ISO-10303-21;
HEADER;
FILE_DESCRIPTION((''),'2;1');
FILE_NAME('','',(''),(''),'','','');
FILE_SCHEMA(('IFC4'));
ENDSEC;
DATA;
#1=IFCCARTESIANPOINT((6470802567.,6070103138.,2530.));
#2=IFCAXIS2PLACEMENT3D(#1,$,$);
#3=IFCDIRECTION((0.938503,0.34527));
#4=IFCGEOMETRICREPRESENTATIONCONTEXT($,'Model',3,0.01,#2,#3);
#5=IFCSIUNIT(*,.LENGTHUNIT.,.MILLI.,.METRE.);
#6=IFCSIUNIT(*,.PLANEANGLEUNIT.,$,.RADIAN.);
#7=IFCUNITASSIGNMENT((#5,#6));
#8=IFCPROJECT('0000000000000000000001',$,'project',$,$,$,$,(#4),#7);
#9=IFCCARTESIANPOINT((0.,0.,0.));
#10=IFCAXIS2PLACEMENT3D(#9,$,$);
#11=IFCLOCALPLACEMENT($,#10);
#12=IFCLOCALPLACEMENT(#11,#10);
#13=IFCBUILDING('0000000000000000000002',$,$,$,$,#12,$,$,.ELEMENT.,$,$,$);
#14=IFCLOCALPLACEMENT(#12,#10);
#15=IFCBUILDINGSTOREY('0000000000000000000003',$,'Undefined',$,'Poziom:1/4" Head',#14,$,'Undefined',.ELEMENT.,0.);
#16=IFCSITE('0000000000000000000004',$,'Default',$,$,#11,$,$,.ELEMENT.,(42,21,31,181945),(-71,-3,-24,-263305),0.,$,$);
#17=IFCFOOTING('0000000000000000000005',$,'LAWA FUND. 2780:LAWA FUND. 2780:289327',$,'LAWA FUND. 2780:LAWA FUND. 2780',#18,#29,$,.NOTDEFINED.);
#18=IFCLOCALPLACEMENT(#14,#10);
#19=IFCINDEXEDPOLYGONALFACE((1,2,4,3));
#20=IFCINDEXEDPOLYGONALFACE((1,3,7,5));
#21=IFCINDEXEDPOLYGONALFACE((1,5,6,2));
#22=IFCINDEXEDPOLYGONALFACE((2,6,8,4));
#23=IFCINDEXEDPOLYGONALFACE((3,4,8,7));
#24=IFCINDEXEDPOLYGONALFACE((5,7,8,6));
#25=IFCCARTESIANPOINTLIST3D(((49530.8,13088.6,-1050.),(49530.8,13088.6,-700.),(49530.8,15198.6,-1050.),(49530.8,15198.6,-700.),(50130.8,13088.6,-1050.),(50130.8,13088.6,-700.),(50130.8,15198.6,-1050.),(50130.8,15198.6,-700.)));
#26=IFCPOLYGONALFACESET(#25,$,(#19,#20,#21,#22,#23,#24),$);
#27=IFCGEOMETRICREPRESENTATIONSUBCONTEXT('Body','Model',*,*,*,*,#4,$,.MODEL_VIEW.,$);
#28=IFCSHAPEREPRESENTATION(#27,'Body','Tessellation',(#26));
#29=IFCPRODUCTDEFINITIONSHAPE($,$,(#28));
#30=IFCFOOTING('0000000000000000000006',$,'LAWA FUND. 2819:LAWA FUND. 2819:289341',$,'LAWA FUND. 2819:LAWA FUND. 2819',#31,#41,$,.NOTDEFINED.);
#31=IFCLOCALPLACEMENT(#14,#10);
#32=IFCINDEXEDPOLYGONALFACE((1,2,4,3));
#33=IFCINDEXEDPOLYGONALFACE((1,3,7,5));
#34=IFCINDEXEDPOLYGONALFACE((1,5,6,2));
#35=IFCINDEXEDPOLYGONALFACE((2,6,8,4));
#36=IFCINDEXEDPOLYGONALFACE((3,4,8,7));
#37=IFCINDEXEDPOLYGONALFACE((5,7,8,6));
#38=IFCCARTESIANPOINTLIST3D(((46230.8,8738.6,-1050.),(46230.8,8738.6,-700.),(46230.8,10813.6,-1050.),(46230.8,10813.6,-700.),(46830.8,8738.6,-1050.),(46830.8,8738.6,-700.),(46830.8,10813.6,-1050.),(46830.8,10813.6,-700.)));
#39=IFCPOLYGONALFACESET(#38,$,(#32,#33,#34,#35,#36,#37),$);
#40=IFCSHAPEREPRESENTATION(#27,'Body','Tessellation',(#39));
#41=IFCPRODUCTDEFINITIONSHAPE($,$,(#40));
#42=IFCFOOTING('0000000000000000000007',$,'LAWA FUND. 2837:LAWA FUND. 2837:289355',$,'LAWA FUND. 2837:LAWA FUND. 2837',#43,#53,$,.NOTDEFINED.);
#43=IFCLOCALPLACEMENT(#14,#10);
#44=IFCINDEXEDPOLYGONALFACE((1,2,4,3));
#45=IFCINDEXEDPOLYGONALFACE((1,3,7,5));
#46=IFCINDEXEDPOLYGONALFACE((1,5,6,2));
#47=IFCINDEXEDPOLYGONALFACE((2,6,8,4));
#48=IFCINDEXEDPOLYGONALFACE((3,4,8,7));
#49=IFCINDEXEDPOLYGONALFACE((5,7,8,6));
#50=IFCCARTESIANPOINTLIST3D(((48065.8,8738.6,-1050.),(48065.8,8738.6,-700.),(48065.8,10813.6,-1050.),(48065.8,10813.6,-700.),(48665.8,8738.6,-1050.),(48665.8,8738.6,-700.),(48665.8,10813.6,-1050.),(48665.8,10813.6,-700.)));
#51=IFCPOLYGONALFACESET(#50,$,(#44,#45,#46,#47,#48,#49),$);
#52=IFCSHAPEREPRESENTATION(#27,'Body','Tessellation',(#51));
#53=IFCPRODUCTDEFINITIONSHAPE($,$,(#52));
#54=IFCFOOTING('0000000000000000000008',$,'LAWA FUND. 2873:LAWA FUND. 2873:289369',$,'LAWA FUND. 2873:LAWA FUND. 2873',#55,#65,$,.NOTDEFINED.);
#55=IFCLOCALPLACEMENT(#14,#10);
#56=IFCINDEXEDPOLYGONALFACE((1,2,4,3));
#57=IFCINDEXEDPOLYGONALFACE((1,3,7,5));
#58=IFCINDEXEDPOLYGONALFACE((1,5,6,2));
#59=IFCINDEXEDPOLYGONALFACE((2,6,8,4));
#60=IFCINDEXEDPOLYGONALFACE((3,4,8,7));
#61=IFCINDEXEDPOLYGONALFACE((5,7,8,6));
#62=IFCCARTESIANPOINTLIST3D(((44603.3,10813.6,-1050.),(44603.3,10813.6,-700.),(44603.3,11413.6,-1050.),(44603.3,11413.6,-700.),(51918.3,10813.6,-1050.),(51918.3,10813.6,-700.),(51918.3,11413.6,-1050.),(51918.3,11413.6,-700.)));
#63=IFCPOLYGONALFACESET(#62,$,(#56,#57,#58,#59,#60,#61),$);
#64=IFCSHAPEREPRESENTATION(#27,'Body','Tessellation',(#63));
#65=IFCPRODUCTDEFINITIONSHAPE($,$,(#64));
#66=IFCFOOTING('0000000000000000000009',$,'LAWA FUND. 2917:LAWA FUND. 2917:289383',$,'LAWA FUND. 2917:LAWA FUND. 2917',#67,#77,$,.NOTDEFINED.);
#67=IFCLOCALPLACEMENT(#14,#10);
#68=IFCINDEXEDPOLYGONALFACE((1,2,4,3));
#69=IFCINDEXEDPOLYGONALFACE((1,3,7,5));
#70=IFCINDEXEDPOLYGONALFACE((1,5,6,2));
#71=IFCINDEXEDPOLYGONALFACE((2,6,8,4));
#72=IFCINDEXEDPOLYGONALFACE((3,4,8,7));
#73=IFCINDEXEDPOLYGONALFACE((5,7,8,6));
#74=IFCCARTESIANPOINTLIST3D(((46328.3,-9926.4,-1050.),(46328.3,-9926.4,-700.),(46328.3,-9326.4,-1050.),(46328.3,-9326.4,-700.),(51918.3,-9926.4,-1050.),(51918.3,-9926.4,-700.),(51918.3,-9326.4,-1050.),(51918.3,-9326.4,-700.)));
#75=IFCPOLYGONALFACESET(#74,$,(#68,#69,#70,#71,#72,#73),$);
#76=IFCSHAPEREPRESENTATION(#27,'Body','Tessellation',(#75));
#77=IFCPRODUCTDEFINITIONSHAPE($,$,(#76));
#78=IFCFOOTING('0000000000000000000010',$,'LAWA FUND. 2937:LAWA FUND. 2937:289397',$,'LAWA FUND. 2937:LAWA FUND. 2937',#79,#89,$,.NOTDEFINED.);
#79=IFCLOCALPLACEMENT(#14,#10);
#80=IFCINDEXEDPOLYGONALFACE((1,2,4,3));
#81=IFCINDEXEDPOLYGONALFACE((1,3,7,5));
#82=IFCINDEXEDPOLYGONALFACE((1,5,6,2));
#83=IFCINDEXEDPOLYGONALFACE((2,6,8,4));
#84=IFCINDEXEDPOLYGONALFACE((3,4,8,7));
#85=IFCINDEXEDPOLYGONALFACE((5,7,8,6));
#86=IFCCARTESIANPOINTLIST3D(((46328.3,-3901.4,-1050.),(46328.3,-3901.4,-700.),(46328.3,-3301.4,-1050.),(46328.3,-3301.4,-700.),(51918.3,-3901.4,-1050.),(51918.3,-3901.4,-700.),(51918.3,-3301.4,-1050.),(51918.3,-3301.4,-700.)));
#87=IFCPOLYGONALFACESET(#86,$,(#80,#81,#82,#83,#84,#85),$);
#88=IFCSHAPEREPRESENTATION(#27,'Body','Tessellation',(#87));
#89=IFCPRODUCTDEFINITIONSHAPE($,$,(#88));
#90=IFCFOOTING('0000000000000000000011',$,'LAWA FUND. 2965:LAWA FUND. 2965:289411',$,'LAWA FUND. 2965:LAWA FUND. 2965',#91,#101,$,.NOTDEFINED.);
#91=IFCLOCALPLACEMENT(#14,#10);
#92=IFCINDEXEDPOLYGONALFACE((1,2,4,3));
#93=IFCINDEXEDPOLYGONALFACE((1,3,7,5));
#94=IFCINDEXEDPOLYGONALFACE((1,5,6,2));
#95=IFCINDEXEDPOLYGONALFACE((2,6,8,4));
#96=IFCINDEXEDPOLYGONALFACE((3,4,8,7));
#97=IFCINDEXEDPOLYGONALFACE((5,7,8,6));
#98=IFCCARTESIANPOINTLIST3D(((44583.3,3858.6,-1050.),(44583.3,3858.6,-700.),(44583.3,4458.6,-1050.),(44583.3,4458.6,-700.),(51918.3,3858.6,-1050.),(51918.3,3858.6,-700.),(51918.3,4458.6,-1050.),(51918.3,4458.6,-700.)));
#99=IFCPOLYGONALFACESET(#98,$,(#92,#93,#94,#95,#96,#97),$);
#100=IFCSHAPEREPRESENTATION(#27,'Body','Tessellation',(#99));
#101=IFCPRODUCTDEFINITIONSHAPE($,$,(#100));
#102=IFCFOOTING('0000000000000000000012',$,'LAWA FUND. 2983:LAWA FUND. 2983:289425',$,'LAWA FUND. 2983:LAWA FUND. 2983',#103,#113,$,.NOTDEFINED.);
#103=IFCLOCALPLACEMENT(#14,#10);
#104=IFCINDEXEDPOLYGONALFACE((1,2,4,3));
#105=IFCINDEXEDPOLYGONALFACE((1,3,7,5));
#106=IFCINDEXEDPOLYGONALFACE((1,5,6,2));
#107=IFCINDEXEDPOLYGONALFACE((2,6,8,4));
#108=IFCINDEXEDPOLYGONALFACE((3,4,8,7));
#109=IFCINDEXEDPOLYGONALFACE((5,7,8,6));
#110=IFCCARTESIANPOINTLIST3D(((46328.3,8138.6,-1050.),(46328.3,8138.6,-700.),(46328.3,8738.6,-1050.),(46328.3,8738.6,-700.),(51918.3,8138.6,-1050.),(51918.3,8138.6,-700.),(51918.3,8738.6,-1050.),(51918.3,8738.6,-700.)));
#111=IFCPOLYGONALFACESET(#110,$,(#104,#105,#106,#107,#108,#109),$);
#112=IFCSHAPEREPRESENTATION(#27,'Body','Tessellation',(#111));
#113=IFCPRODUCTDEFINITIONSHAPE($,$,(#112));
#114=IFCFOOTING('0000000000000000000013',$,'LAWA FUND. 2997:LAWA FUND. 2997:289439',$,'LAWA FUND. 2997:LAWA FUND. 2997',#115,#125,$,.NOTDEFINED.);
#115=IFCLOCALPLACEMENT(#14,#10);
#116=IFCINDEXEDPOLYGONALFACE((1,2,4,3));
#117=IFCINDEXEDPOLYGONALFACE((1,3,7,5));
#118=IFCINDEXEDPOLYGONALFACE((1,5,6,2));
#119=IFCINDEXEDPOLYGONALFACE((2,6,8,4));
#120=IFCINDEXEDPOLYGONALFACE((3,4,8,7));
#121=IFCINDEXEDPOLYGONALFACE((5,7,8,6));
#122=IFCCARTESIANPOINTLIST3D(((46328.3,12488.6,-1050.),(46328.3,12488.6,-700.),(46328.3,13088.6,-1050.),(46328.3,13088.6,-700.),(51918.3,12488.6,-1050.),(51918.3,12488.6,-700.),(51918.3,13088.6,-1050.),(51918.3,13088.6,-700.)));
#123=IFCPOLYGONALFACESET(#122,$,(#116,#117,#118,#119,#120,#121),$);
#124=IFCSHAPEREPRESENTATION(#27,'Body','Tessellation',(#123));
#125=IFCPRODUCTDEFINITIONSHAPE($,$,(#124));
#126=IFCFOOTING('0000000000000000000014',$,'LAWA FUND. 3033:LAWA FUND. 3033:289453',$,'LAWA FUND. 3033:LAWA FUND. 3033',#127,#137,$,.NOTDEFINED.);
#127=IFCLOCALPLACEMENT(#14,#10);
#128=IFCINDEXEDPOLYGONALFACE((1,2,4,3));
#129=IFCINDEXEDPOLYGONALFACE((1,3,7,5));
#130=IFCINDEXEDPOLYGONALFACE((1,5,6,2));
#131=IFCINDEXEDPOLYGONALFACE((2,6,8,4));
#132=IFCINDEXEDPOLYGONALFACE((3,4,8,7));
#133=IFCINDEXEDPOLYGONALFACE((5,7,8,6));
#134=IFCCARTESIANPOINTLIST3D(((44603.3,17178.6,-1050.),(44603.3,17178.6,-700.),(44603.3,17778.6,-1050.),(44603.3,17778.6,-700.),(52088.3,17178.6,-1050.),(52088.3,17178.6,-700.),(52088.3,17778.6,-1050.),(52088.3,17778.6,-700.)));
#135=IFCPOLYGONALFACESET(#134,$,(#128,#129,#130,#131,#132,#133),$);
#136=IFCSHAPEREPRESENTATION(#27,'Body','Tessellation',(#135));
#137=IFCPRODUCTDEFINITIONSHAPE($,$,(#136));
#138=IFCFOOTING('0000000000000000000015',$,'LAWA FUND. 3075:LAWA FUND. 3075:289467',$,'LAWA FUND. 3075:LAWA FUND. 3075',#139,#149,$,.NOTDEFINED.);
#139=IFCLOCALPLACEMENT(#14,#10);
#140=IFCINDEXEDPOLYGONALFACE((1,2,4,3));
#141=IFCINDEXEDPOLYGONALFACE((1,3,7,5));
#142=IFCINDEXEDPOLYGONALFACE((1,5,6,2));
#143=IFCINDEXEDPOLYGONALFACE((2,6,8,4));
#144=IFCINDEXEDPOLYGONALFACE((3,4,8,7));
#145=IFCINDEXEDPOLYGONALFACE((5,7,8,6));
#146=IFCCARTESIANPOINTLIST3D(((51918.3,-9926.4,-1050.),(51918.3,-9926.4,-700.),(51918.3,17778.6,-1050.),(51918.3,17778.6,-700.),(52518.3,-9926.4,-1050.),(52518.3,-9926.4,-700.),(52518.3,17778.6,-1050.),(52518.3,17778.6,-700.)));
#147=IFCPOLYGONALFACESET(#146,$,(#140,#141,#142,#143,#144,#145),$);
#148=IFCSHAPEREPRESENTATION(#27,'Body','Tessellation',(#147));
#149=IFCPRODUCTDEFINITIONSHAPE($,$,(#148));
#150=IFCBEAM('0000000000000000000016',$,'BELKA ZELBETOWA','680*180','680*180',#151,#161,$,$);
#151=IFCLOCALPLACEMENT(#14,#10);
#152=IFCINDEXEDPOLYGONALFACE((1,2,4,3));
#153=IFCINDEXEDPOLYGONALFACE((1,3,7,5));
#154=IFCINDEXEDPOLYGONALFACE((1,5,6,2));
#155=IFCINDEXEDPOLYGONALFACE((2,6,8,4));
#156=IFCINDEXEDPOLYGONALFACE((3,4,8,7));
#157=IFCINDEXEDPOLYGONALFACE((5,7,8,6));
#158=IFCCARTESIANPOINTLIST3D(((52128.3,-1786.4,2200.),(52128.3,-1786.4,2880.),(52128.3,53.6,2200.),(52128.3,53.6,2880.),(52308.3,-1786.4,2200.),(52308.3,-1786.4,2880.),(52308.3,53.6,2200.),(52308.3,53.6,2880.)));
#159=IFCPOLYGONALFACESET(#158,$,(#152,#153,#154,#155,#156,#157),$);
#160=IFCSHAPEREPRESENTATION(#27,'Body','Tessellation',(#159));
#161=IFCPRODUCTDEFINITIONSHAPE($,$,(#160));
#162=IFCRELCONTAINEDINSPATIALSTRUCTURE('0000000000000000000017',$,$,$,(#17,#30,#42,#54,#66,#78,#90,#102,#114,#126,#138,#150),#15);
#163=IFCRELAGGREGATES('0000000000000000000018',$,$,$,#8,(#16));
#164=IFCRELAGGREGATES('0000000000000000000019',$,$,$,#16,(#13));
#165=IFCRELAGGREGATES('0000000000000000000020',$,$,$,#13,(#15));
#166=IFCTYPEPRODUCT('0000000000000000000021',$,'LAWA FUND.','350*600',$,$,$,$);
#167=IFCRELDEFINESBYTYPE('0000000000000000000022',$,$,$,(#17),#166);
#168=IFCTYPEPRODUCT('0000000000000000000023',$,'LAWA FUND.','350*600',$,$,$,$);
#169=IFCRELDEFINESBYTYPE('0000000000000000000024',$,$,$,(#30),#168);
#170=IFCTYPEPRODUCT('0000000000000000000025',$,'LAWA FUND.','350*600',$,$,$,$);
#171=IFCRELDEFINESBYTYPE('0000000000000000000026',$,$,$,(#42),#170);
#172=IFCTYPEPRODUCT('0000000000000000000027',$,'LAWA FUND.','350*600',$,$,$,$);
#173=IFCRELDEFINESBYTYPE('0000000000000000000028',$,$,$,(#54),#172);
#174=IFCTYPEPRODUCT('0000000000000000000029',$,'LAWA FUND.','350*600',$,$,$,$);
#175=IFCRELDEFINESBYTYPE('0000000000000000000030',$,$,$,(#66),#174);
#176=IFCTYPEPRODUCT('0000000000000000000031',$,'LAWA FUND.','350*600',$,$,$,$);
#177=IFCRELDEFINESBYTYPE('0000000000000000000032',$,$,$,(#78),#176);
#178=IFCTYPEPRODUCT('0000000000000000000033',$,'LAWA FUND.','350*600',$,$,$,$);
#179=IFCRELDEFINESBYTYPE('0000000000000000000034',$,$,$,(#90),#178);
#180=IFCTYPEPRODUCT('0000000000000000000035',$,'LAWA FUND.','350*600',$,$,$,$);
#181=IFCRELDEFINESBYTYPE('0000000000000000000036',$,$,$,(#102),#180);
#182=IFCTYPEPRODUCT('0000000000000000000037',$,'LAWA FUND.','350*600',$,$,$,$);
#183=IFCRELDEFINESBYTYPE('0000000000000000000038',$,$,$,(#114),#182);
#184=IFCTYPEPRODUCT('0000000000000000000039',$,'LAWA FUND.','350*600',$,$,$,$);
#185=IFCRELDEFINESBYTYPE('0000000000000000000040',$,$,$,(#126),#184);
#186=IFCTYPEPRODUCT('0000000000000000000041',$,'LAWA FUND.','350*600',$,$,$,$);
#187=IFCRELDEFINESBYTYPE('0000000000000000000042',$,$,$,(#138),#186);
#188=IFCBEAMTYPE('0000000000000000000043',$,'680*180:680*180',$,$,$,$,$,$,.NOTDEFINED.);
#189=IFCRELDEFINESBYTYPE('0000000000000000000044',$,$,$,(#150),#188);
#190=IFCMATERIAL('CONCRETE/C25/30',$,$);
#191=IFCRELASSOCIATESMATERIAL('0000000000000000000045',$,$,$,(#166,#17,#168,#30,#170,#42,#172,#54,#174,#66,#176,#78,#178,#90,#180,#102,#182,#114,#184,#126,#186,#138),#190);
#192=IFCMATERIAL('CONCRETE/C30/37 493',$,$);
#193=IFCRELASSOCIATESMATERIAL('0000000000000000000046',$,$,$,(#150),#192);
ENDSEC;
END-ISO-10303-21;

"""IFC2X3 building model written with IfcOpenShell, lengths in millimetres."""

from ifc_helpers import new_model, si_unit, direction, frame, frame_2d, origin, origin_2d_with_axis, place, context, subcontext, project, spatial, rectangle, extrude, source, transform, mapped, material, type_object, type_shapes, element, save


model = new_model("IFC2X3")

# Units and contexts
model_context = context("Model", 3, precision=0.01, world=frame((6470802567.0, 6070103138.0, 2530.0)), true_north=direction((0.938503, 0.34527)))
body_context = subcontext(model_context, "Body", "Model", "MODEL_VIEW")
ifc_project = project(units=[si_unit("LENGTHUNIT", "METRE", prefix="MILLI"), si_unit("PLANEANGLEUNIT", "RADIAN")], contexts=[model_context])

# Site, building, storey
site_placement = place(None, origin())
site = spatial("IfcSite", under=ifc_project, at=site_placement, Name="Default", CompositionType="ELEMENT", RefLatitude=(42, 21, 31, 181945), RefLongitude=(-71, -3, -24, -263305), RefElevation=0.0)
building_placement = place(site_placement, origin())
building = spatial("IfcBuilding", under=site, at=building_placement, CompositionType="ELEMENT")
storey_placement = place(building_placement, origin())
storey = spatial("IfcBuildingStorey", under=building, at=storey_placement, Name="Undefined", ObjectType="Poziom:1/4\" Head", LongName="Undefined", CompositionType="ELEMENT", Elevation=0.0)

# Footings
ifc_material_1 = material(Name="CONCRETE/C25/30")
type_product_1 = type_object("IfcTypeProduct", Name="LAWA FUND.", Description="350*600", material=ifc_material_1)
shared_shape_1 = source(origin(), body_context, "Body", "SweptSolid", [
    extrude(rectangle(XDim=600.0, YDim=2110.0, at=origin_2d_with_axis()), frame((49830.8, 14143.6, -1050.0)), (0.0, 0.0, 1.0), 350.0),
])
type_shapes(type_product_1, [shared_shape_1])
footing_1_placement = place(storey_placement, origin())
element("IfcFooting", 1, at=footing_1_placement, inside=storey, type_object=type_product_1, material=ifc_material_1, Name="LAWA FUND. 2780:LAWA FUND. 2780:289327", ObjectType="LAWA FUND. 2780:LAWA FUND. 2780", PredefinedType="NOTDEFINED", context=body_context, shape_type="MappedRepresentation", body=[
    mapped(shared_shape_1, transform((0.0, 0.0, 0.0), scale=1.0)),
])
type_product_2 = type_object("IfcTypeProduct", Name="LAWA FUND.", Description="350*600", material=ifc_material_1)
shared_shape_2 = source(origin(), body_context, "Body", "SweptSolid", [
    extrude(rectangle(XDim=600.0, YDim=2075.0, at=origin_2d_with_axis()), frame((46530.8, 9776.1, -1050.0)), (0.0, 0.0, 1.0), 350.0),
])
type_shapes(type_product_2, [shared_shape_2])
footing_2_placement = place(storey_placement, origin())
element("IfcFooting", 2, at=footing_2_placement, inside=storey, type_object=type_product_2, material=ifc_material_1, Name="LAWA FUND. 2819:LAWA FUND. 2819:289341", ObjectType="LAWA FUND. 2819:LAWA FUND. 2819", PredefinedType="NOTDEFINED", context=body_context, shape_type="MappedRepresentation", body=[
    mapped(shared_shape_2, transform((0.0, 0.0, 0.0), scale=1.0)),
])
type_product_3 = type_object("IfcTypeProduct", Name="LAWA FUND.", Description="350*600", material=ifc_material_1)
shared_shape_3 = source(origin(), body_context, "Body", "SweptSolid", [
    extrude(rectangle(XDim=600.0, YDim=2075.0, at=origin_2d_with_axis()), frame((48365.8, 9776.1, -1050.0)), (0.0, 0.0, 1.0), 350.0),
])
type_shapes(type_product_3, [shared_shape_3])
footing_3_placement = place(storey_placement, origin())
element("IfcFooting", 3, at=footing_3_placement, inside=storey, type_object=type_product_3, material=ifc_material_1, Name="LAWA FUND. 2837:LAWA FUND. 2837:289355", ObjectType="LAWA FUND. 2837:LAWA FUND. 2837", PredefinedType="NOTDEFINED", context=body_context, shape_type="MappedRepresentation", body=[
    mapped(shared_shape_3, transform((0.0, 0.0, 0.0), scale=1.0)),
])
type_product_4 = type_object("IfcTypeProduct", Name="LAWA FUND.", Description="350*600", material=ifc_material_1)
shared_shape_4 = source(origin(), body_context, "Body", "SweptSolid", [
    extrude(rectangle(XDim=600.0, YDim=7315.0, at=origin_2d_with_axis()), frame((48260.8, 11113.6, -1050.0), z_axis=(0.0, 0.0, 1.0), x_axis=(0.0, 1.0, 0.0)), (0.0, 0.0, 1.0), 350.0),
])
type_shapes(type_product_4, [shared_shape_4])
footing_4_placement = place(storey_placement, origin())
element("IfcFooting", 4, at=footing_4_placement, inside=storey, type_object=type_product_4, material=ifc_material_1, Name="LAWA FUND. 2873:LAWA FUND. 2873:289369", ObjectType="LAWA FUND. 2873:LAWA FUND. 2873", PredefinedType="NOTDEFINED", context=body_context, shape_type="MappedRepresentation", body=[
    mapped(shared_shape_4, transform((0.0, 0.0, 0.0), scale=1.0)),
])
type_product_5 = type_object("IfcTypeProduct", Name="LAWA FUND.", Description="350*600", material=ifc_material_1)
shared_shape_5 = source(origin(), body_context, "Body", "SweptSolid", [
    extrude(rectangle(XDim=600.0, YDim=5590.0, at=frame_2d((0.0, 0.0), x_axis=(1.0, 0.0))), frame((49123.3, -9626.4, -1050.0), z_axis=(0.0, 0.0, 1.0), x_axis=(0.0, 1.0, 0.0)), (0.0, 0.0, 1.0), 350.0),
])
type_shapes(type_product_5, [shared_shape_5])
footing_5_placement = place(storey_placement, origin())
element("IfcFooting", 5, at=footing_5_placement, inside=storey, type_object=type_product_5, material=ifc_material_1, Name="LAWA FUND. 2917:LAWA FUND. 2917:289383", ObjectType="LAWA FUND. 2917:LAWA FUND. 2917", PredefinedType="NOTDEFINED", context=body_context, shape_type="MappedRepresentation", body=[
    mapped(shared_shape_5, transform((0.0, 0.0, 0.0), scale=1.0)),
])
type_product_6 = type_object("IfcTypeProduct", Name="LAWA FUND.", Description="350*600", material=ifc_material_1)
shared_shape_6 = source(origin(), body_context, "Body", "SweptSolid", [
    extrude(rectangle(XDim=600.0, YDim=5590.0, at=origin_2d_with_axis()), frame((49123.3, -3601.4, -1050.0), z_axis=(0.0, 0.0, 1.0), x_axis=(0.0, 1.0, 0.0)), (0.0, 0.0, 1.0), 350.0),
])
type_shapes(type_product_6, [shared_shape_6])
footing_6_placement = place(storey_placement, origin())
element("IfcFooting", 6, at=footing_6_placement, inside=storey, type_object=type_product_6, material=ifc_material_1, Name="LAWA FUND. 2937:LAWA FUND. 2937:289397", ObjectType="LAWA FUND. 2937:LAWA FUND. 2937", PredefinedType="NOTDEFINED", context=body_context, shape_type="MappedRepresentation", body=[
    mapped(shared_shape_6, transform((0.0, 0.0, 0.0), scale=1.0)),
])
type_product_7 = type_object("IfcTypeProduct", Name="LAWA FUND.", Description="350*600", material=ifc_material_1)
shared_shape_7 = source(origin(), body_context, "Body", "SweptSolid", [
    extrude(rectangle(XDim=600.0, YDim=7335.0, at=origin_2d_with_axis()), frame((48250.8, 4158.6, -1050.0), z_axis=(0.0, 0.0, 1.0), x_axis=(0.0, 1.0, 0.0)), (0.0, 0.0, 1.0), 350.0),
])
type_shapes(type_product_7, [shared_shape_7])
footing_7_placement = place(storey_placement, origin())
element("IfcFooting", 7, at=footing_7_placement, inside=storey, type_object=type_product_7, material=ifc_material_1, Name="LAWA FUND. 2965:LAWA FUND. 2965:289411", ObjectType="LAWA FUND. 2965:LAWA FUND. 2965", PredefinedType="NOTDEFINED", context=body_context, shape_type="MappedRepresentation", body=[
    mapped(shared_shape_7, transform((0.0, 0.0, 0.0), scale=1.0)),
])
type_product_8 = type_object("IfcTypeProduct", Name="LAWA FUND.", Description="350*600", material=ifc_material_1)
shared_shape_8 = source(origin(), body_context, "Body", "SweptSolid", [
    extrude(rectangle(XDim=600.0, YDim=5590.0, at=frame_2d((0.0, 0.0), x_axis=(1.0, 0.0))), frame((49123.3, 8438.6, -1050.0), z_axis=(0.0, 0.0, 1.0), x_axis=(0.0, 1.0, 0.0)), (0.0, 0.0, 1.0), 350.0),
])
type_shapes(type_product_8, [shared_shape_8])
footing_8_placement = place(storey_placement, origin())
element("IfcFooting", 8, at=footing_8_placement, inside=storey, type_object=type_product_8, material=ifc_material_1, Name="LAWA FUND. 2983:LAWA FUND. 2983:289425", ObjectType="LAWA FUND. 2983:LAWA FUND. 2983", PredefinedType="NOTDEFINED", context=body_context, shape_type="MappedRepresentation", body=[
    mapped(shared_shape_8, transform((0.0, 0.0, 0.0), scale=1.0)),
])
type_product_9 = type_object("IfcTypeProduct", Name="LAWA FUND.", Description="350*600", material=ifc_material_1)
shared_shape_9 = source(origin(), body_context, "Body", "SweptSolid", [
    extrude(rectangle(XDim=600.0, YDim=5590.0, at=frame_2d((0.0, 0.0), x_axis=(1.0, 0.0))), frame((49123.3, 12788.6, -1050.0), z_axis=(0.0, 0.0, 1.0), x_axis=(0.0, 1.0, 0.0)), (0.0, 0.0, 1.0), 350.0),
])
type_shapes(type_product_9, [shared_shape_9])
footing_9_placement = place(storey_placement, origin())
element("IfcFooting", 9, at=footing_9_placement, inside=storey, type_object=type_product_9, material=ifc_material_1, Name="LAWA FUND. 2997:LAWA FUND. 2997:289439", ObjectType="LAWA FUND. 2997:LAWA FUND. 2997", PredefinedType="NOTDEFINED", context=body_context, shape_type="MappedRepresentation", body=[
    mapped(shared_shape_9, transform((0.0, 0.0, 0.0), scale=1.0)),
])
type_product_10 = type_object("IfcTypeProduct", Name="LAWA FUND.", Description="350*600", material=ifc_material_1)
shared_shape_10 = source(origin(), body_context, "Body", "SweptSolid", [
    extrude(rectangle(XDim=600.0, YDim=7485.0, at=frame_2d((0.0, 0.0), x_axis=(1.0, 0.0))), frame((48345.8, 17478.6, -1050.0), z_axis=(0.0, 0.0, 1.0), x_axis=(0.0, 1.0, 0.0)), (0.0, 0.0, 1.0), 350.0),
])
type_shapes(type_product_10, [shared_shape_10])
footing_10_placement = place(storey_placement, origin())
element("IfcFooting", 10, at=footing_10_placement, inside=storey, type_object=type_product_10, material=ifc_material_1, Name="LAWA FUND. 3033:LAWA FUND. 3033:289453", ObjectType="LAWA FUND. 3033:LAWA FUND. 3033", PredefinedType="NOTDEFINED", context=body_context, shape_type="MappedRepresentation", body=[
    mapped(shared_shape_10, transform((0.0, 0.0, 0.0), scale=1.0)),
])
type_product_11 = type_object("IfcTypeProduct", Name="LAWA FUND.", Description="350*600", material=ifc_material_1)
shared_shape_11 = source(origin(), body_context, "Body", "SweptSolid", [
    extrude(rectangle(XDim=600.0, YDim=27705.0, at=frame_2d((0.0, 0.0), x_axis=(1.0, 0.0))), frame((52218.3, 3926.1, -1050.0)), (0.0, 0.0, 1.0), 350.0),
])
type_shapes(type_product_11, [shared_shape_11])
footing_11_placement = place(storey_placement, origin())
element("IfcFooting", 11, at=footing_11_placement, inside=storey, type_object=type_product_11, material=ifc_material_1, Name="LAWA FUND. 3075:LAWA FUND. 3075:289467", ObjectType="LAWA FUND. 3075:LAWA FUND. 3075", PredefinedType="NOTDEFINED", context=body_context, shape_type="MappedRepresentation", body=[
    mapped(shared_shape_11, transform((0.0, 0.0, 0.0), scale=1.0)),
])

# Beam
ifc_material_2 = material(Name="CONCRETE/C30/37 493")
beam_type_1 = type_object("IfcBeamType", Name="680*180:680*180", PredefinedType="NOTDEFINED")
beam_1_placement = place(storey_placement, origin())
element("IfcBeam", 12, at=beam_1_placement, inside=storey, type_object=beam_type_1, material=ifc_material_2, Name="BELKA ZELBETOWA", Description="680*180", ObjectType="680*180", context=body_context, shape_type="SweptSolid", body=[
    extrude(rectangle(XDim=680.0, YDim=1840.0, at=frame_2d((0.0, 0.0), x_axis=(0.0, 1.0))), frame((52128.3, -866.4, 2540.0), z_axis=(1.0, 0.0, 0.0), x_axis=(0.0, -1.0, 0.0)), (0.0, 0.0, 1.0), 180.0),
])

save(model, "model.ifc")
